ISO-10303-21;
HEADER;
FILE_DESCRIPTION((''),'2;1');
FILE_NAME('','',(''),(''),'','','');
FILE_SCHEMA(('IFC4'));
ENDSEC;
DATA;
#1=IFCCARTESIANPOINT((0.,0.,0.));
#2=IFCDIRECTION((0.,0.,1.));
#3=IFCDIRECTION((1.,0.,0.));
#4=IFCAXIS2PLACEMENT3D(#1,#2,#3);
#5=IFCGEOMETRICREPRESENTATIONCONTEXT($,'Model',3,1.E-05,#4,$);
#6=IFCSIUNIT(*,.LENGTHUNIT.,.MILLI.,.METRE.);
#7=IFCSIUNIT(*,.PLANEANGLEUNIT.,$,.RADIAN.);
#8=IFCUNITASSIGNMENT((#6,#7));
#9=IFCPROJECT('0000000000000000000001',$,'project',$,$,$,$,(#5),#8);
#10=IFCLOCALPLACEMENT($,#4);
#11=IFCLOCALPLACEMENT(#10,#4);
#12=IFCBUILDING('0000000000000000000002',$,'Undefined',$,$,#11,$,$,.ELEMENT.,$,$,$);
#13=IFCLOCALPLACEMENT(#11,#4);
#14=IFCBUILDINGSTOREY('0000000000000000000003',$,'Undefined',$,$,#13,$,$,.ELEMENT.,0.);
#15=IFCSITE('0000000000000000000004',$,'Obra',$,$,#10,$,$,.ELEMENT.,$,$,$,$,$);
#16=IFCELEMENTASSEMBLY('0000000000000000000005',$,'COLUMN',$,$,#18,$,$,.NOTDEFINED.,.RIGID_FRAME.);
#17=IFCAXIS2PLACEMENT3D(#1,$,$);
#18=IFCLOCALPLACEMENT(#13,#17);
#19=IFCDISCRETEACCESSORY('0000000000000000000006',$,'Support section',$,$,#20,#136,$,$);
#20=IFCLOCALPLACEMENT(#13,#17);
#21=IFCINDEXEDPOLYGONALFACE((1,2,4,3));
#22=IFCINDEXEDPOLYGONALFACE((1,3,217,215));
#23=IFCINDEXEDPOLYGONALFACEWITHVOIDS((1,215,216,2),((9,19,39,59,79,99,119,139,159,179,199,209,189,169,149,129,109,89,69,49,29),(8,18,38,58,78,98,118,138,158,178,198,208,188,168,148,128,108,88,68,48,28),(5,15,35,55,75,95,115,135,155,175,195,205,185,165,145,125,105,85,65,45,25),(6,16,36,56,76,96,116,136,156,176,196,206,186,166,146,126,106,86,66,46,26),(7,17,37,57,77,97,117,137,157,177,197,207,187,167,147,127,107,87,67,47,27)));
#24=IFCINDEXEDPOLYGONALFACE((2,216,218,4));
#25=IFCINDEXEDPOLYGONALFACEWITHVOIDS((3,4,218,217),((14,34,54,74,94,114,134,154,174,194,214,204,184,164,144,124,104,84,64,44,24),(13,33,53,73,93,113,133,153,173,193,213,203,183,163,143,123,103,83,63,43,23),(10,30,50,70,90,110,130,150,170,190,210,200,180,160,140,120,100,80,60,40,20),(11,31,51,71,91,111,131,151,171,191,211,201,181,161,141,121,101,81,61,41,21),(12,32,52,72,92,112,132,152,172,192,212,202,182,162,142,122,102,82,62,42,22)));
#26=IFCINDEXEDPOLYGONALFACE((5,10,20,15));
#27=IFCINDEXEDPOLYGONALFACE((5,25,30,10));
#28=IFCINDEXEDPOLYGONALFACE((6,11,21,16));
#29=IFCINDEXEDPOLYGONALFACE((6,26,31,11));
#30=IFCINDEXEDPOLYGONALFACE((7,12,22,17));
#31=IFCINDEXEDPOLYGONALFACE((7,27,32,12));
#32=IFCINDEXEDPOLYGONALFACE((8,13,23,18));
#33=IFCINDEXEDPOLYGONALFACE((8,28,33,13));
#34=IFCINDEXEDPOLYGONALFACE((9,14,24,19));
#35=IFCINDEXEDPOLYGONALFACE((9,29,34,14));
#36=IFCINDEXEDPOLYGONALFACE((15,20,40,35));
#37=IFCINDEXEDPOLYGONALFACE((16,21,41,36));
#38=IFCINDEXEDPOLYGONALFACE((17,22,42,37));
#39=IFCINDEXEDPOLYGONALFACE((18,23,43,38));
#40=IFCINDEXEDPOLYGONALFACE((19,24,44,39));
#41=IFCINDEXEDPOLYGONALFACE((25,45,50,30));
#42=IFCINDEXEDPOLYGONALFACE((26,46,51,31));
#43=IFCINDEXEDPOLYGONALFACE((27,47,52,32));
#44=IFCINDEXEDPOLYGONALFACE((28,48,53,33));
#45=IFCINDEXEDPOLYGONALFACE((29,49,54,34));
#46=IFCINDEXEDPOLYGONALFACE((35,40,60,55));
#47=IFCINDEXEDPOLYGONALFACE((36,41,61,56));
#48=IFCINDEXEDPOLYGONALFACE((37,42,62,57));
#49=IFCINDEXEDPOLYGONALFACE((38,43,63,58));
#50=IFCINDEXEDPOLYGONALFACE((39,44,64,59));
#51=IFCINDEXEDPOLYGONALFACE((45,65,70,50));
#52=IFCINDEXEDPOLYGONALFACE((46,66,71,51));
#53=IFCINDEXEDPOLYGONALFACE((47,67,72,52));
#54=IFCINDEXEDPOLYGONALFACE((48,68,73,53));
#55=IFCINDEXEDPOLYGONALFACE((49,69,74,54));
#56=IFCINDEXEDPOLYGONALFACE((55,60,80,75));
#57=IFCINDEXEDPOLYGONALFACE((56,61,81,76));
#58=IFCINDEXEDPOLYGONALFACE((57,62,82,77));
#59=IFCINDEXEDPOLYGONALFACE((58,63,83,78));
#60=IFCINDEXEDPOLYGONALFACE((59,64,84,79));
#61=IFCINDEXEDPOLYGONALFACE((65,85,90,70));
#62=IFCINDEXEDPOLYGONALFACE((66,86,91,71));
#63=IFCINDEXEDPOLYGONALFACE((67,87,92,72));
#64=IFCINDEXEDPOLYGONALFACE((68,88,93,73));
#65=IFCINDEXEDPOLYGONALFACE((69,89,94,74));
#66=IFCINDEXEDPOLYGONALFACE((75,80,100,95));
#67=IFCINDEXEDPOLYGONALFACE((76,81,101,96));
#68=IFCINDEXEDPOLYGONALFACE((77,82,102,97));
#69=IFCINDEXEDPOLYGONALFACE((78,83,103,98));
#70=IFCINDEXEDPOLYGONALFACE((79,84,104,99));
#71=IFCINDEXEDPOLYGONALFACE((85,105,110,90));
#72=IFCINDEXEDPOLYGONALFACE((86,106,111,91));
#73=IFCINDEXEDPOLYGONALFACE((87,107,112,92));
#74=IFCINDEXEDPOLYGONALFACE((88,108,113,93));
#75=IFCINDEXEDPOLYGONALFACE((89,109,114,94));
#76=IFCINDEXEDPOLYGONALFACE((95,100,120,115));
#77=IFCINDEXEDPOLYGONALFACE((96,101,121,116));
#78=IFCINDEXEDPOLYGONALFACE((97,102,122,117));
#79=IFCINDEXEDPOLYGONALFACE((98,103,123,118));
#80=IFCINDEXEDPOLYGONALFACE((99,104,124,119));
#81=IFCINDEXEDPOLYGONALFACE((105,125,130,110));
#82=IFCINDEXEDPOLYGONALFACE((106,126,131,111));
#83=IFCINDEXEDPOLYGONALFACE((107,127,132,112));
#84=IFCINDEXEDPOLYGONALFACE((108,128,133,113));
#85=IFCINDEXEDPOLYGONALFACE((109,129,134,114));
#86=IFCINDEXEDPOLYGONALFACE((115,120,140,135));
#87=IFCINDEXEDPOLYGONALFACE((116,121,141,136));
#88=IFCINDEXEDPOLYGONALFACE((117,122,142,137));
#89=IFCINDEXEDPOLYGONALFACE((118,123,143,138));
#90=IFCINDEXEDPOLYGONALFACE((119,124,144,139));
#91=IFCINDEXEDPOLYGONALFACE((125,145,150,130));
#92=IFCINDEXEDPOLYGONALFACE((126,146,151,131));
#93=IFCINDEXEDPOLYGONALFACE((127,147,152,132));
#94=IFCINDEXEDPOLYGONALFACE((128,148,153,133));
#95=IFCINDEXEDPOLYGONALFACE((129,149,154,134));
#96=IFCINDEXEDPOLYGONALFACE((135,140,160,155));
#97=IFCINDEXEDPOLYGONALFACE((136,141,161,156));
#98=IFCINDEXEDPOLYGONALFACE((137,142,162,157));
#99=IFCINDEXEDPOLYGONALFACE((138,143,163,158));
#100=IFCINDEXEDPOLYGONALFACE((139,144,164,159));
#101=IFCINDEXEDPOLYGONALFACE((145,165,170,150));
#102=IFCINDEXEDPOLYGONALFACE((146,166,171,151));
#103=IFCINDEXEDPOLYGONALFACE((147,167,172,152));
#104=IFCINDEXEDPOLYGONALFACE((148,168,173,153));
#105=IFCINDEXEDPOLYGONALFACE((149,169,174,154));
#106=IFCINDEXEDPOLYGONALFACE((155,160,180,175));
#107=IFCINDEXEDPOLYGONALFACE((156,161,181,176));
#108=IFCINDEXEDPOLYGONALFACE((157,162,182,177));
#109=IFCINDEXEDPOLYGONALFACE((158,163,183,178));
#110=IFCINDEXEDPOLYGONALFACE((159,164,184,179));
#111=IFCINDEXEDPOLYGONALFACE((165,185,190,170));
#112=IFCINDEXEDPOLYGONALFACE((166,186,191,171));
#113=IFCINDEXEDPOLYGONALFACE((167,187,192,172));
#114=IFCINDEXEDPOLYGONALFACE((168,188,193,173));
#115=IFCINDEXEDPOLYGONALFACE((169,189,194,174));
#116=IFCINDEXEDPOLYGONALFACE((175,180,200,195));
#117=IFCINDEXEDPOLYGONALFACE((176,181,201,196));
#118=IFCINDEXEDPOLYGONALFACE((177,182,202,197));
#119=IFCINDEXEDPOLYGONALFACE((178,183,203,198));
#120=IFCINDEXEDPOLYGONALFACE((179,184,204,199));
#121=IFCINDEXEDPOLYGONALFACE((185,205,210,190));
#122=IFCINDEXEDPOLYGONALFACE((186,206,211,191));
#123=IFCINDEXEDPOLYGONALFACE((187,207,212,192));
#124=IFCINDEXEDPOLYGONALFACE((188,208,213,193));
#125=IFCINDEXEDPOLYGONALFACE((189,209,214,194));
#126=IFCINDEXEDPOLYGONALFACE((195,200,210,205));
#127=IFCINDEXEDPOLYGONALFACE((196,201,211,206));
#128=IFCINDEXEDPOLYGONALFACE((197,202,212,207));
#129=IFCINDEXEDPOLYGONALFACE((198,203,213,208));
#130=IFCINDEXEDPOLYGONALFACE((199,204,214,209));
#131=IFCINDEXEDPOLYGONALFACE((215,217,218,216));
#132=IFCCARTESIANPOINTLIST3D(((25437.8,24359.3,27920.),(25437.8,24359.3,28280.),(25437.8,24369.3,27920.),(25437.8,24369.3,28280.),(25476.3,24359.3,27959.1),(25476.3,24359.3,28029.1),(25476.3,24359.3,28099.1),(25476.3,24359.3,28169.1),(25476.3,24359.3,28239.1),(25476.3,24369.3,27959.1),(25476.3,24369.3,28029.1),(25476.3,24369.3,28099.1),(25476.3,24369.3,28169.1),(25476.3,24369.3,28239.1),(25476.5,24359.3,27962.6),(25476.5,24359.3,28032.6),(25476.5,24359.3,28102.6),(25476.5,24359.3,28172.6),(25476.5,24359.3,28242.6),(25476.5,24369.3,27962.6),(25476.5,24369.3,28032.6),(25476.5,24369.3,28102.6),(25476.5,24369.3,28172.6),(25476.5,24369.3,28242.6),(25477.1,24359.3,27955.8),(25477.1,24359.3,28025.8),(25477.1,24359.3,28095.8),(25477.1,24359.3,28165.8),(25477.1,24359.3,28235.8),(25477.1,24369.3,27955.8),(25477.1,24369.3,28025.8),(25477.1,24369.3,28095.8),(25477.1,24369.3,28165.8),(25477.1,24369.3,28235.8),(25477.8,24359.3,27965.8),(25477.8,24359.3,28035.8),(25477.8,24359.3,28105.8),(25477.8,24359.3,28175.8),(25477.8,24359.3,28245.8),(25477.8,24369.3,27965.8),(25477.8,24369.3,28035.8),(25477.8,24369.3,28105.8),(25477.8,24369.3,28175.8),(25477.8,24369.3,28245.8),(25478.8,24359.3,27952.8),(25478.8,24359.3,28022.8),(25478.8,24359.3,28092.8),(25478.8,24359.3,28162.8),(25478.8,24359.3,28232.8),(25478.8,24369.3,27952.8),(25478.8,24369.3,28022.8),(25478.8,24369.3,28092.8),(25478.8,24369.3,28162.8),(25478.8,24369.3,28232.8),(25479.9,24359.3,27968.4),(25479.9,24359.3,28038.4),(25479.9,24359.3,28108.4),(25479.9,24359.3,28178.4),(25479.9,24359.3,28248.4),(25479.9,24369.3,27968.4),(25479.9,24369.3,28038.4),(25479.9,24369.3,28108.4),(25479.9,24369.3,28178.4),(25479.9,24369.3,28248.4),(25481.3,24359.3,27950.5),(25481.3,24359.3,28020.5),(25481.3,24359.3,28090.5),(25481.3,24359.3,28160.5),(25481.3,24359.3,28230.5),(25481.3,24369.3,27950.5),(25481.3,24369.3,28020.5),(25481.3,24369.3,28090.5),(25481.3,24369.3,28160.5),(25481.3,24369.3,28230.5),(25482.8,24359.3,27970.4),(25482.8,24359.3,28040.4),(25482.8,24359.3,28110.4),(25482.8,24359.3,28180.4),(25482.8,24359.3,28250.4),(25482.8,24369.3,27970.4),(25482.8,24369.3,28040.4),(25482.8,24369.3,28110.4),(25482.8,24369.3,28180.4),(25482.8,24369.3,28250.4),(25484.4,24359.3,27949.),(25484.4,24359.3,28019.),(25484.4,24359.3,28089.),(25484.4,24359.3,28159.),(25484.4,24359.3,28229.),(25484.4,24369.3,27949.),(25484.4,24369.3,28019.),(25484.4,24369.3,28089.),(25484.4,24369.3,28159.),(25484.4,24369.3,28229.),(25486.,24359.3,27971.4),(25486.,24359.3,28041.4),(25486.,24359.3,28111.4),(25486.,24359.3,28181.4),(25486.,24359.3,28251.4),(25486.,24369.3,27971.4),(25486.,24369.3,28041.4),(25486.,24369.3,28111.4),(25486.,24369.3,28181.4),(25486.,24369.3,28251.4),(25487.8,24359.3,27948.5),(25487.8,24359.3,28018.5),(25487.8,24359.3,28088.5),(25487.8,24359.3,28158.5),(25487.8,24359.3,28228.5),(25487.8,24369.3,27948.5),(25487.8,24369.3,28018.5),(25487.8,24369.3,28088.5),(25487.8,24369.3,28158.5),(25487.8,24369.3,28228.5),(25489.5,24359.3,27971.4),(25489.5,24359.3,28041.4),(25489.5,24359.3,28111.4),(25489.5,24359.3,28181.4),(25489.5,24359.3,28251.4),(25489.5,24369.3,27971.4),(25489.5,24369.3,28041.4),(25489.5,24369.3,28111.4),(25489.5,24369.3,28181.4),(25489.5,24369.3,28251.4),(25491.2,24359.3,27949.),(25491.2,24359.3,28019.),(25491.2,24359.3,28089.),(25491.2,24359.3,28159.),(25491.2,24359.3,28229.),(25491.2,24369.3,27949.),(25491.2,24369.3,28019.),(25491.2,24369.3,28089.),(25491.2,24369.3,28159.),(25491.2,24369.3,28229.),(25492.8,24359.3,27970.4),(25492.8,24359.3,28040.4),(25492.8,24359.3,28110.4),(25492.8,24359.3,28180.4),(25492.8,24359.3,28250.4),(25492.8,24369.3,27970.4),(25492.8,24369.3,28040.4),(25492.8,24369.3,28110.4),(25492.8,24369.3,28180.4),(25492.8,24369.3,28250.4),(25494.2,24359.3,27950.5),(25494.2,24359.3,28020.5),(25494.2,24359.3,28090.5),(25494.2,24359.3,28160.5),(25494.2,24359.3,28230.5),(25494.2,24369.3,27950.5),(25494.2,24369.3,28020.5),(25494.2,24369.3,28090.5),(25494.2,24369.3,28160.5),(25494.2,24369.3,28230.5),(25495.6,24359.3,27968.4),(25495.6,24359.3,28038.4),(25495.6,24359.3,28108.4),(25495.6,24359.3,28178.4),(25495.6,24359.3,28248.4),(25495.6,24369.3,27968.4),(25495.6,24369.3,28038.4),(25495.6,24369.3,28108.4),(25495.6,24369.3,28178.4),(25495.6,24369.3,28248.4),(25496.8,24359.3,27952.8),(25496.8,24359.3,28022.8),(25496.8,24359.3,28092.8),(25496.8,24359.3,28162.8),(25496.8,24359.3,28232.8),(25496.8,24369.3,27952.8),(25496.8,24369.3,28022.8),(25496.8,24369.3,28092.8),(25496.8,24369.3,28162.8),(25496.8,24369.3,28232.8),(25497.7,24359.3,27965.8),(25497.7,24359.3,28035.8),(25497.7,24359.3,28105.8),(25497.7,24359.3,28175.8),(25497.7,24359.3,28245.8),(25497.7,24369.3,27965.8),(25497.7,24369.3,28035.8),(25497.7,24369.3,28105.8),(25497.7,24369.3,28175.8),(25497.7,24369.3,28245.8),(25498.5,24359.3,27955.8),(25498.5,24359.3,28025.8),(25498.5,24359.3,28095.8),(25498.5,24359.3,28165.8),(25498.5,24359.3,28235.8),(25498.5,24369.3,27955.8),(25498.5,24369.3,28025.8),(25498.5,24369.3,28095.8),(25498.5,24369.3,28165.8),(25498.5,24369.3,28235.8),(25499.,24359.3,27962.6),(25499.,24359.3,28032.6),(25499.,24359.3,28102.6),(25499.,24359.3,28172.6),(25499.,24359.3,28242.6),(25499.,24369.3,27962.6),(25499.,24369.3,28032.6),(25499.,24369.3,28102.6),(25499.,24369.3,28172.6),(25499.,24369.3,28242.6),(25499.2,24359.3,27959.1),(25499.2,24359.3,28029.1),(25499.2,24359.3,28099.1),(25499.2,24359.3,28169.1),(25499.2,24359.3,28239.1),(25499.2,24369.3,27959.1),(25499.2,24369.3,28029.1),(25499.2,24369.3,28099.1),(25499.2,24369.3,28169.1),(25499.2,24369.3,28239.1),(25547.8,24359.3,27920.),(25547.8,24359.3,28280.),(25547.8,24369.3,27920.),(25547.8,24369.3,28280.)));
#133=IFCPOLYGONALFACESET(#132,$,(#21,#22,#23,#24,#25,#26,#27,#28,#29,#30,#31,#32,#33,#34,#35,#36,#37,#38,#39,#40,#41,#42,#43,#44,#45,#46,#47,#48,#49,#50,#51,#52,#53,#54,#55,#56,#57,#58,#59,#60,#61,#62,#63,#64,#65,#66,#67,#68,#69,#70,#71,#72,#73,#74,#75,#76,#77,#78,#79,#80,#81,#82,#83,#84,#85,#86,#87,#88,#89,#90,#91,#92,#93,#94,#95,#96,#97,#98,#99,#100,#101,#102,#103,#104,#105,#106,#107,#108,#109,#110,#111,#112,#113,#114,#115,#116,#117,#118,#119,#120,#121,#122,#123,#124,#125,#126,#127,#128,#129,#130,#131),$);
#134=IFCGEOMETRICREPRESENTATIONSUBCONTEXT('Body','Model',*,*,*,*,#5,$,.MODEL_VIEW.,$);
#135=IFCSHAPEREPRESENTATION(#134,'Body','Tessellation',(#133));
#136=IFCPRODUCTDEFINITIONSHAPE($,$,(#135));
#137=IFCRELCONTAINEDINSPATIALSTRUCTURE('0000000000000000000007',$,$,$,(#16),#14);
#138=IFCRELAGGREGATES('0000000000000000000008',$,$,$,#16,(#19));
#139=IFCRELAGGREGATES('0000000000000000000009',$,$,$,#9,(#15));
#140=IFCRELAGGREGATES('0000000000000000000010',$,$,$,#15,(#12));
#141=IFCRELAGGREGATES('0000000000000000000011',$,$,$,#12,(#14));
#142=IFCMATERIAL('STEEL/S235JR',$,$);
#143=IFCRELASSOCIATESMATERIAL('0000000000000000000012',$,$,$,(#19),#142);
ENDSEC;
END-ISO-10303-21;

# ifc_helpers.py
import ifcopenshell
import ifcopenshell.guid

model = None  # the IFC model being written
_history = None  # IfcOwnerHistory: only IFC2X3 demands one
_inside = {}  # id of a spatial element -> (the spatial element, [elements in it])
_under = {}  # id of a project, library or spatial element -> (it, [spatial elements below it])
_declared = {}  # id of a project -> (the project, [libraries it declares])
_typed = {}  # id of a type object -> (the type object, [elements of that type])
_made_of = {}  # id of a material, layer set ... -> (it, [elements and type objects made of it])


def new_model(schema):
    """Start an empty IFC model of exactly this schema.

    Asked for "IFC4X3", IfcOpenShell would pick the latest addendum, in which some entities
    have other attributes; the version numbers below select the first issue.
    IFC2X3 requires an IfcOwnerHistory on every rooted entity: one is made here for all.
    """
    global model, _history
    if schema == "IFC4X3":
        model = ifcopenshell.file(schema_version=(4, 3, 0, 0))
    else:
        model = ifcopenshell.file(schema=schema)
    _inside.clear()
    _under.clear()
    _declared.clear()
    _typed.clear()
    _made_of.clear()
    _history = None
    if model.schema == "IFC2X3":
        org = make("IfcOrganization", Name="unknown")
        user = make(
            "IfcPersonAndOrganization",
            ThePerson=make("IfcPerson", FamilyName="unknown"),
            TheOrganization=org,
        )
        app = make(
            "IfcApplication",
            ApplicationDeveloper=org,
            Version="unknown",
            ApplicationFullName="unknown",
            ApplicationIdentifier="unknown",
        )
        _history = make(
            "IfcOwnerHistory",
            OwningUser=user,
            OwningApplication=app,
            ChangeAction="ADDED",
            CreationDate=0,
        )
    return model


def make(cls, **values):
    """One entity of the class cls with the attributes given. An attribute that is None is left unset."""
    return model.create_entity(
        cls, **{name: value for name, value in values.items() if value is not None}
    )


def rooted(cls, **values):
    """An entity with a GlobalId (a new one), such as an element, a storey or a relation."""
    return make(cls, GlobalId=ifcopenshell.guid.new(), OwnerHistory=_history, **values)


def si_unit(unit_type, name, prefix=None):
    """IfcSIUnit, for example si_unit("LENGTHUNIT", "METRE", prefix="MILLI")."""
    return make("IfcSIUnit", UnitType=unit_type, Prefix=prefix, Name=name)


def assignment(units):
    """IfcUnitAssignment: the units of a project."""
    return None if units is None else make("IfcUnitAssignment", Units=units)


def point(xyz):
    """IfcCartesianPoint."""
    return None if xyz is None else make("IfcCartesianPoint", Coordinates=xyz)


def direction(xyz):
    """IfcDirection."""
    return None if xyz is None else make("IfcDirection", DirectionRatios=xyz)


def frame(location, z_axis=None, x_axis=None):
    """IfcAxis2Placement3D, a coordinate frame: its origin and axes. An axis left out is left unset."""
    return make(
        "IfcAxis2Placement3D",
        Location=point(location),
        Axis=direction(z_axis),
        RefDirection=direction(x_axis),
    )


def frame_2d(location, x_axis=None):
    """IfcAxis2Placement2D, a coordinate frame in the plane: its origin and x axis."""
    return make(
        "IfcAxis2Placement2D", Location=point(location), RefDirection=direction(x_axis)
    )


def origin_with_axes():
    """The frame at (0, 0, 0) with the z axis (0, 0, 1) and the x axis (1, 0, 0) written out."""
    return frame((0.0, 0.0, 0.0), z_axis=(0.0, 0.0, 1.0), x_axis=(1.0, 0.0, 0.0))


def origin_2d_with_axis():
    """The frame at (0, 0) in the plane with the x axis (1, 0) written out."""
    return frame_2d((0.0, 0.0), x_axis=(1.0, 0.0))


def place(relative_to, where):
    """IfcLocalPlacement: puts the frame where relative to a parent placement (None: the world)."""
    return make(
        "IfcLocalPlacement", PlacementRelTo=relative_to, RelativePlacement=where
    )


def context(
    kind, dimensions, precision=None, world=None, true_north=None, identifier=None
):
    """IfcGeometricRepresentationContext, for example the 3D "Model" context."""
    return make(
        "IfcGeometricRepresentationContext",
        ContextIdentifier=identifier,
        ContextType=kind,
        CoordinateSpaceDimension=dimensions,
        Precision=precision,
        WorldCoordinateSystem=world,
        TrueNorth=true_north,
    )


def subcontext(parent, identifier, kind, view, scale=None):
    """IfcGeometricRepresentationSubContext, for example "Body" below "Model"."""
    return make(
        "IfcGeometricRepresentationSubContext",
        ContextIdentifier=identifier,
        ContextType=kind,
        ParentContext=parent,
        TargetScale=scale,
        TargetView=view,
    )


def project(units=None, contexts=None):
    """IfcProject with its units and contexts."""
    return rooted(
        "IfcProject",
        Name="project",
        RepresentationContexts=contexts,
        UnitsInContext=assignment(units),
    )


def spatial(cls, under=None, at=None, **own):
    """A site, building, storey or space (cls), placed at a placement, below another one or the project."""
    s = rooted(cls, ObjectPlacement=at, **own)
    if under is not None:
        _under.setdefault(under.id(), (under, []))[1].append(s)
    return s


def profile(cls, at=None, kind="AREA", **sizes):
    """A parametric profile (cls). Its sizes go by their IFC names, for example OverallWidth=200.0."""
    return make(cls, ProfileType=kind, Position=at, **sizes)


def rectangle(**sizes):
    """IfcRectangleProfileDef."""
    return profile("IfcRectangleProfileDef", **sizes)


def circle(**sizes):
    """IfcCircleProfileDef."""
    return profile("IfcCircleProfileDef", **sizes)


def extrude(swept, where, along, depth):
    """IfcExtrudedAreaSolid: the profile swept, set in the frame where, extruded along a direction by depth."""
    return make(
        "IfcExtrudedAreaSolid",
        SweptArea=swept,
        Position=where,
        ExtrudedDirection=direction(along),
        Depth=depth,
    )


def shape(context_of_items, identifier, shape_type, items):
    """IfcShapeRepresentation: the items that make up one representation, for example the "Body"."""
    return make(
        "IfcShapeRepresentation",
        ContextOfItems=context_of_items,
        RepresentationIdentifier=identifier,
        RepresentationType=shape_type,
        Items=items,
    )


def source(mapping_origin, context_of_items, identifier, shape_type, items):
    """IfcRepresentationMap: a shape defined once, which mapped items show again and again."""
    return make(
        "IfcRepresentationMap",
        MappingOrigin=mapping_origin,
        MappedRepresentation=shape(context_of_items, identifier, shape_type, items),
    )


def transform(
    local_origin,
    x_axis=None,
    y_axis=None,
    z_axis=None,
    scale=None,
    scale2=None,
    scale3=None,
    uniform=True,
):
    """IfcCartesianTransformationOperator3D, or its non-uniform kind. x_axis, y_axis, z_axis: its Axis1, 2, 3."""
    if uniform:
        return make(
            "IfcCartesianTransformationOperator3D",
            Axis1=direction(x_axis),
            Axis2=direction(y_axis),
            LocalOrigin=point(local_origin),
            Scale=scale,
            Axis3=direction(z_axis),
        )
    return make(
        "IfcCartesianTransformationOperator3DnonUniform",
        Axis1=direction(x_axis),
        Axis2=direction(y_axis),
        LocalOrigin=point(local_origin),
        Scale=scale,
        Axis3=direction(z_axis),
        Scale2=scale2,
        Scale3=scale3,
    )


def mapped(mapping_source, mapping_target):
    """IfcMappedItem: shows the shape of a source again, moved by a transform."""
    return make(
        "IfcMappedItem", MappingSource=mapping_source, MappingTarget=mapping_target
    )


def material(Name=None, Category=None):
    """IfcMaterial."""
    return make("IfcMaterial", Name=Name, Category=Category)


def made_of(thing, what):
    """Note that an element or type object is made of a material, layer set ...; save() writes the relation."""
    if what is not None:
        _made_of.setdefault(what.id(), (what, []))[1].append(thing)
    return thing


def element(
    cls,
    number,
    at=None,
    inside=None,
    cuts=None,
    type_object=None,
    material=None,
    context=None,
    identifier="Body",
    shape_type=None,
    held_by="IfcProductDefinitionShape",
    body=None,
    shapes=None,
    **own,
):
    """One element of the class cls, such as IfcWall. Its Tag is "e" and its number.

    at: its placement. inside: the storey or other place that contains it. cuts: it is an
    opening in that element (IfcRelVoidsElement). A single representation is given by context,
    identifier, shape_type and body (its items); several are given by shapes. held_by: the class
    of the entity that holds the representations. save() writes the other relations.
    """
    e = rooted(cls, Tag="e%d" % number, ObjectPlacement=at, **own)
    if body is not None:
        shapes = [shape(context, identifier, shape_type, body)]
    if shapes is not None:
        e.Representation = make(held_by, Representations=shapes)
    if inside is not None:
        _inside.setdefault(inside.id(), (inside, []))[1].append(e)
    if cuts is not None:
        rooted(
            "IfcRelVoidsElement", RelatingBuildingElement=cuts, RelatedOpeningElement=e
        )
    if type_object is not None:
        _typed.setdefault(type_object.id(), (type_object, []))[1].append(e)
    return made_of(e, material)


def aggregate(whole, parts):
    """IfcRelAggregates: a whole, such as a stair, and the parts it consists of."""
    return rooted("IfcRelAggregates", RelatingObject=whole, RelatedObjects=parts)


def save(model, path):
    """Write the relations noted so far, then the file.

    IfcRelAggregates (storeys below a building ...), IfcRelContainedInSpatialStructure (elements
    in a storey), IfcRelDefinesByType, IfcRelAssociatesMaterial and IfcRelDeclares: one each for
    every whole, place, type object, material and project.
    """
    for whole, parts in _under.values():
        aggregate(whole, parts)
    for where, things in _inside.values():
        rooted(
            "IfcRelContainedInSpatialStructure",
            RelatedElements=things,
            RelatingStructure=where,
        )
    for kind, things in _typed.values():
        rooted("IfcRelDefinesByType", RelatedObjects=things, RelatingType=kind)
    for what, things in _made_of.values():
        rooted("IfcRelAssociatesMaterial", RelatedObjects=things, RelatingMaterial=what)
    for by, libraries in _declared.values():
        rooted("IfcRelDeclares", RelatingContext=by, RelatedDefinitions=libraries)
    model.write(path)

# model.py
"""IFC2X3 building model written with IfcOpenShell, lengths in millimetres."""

from ifc_helpers import new_model, si_unit, frame, origin_with_axes, origin_2d_with_axis, place, context, subcontext, project, spatial, rectangle, circle, extrude, source, transform, mapped, material, element, aggregate, save


model = new_model("IFC2X3")

# Units and contexts
model_context = context("Model", 3, precision=1e-05, world=origin_with_axes())
body_context = subcontext(model_context, "Body", "Model", "MODEL_VIEW")
ifc_project = project(units=[si_unit("LENGTHUNIT", "METRE", prefix="MILLI"), si_unit("PLANEANGLEUNIT", "RADIAN")], contexts=[model_context])

# Site, building, storey
site_placement = place(None, origin_with_axes())
site = spatial("IfcSite", under=ifc_project, at=site_placement, Name="Obra", CompositionType="ELEMENT")
building_placement = place(site_placement, origin_with_axes())
building = spatial("IfcBuilding", under=site, at=building_placement, Name="Undefined", CompositionType="ELEMENT")
storey_placement = place(building_placement, origin_with_axes())
storey = spatial("IfcBuildingStorey", under=building, at=storey_placement, Name="Undefined", CompositionType="ELEMENT", Elevation=0.0)

# Element assembly
ifc_material_1 = material(Name="STEEL/S235JR")
assembly_1_placement = place(storey_placement, origin_with_axes())
assembly_1 = element("IfcElementAssembly", 1, at=assembly_1_placement, inside=storey, Name="COLUMN", AssemblyPlace="NOTDEFINED", PredefinedType="RIGID_FRAME")

# Shared definitions
shared_shape_1 = source(origin_with_axes(), body_context, "Body", "SweptSolid", [
    extrude(circle(Radius=11.5, at=origin_2d_with_axis()), frame((0.0, -14.4, 0.0), z_axis=(0.0, 1.0, 0.0), x_axis=(1.0, 0.0, 0.0)), (0.0, 0.0, 1.0), 10.2),
])

# Discrete accessory, opening
discrete_accessory_1_placement = place(assembly_1_placement, frame((25492.8, 24364.3, 27920.0), z_axis=(0.0, 0.0, 1.0), x_axis=(1.0, 0.0, 0.0)))
discrete_accessory_1 = element("IfcDiscreteAccessory", 2, at=discrete_accessory_1_placement, material=ifc_material_1, Name="Support section", context=body_context, shape_type="SweptSolid", body=[
    extrude(rectangle(XDim=10.0, YDim=110.0, at=origin_2d_with_axis()), frame((0.0, 0.0, 360.0), z_axis=(0.0, 0.0, -1.0), x_axis=(0.0, 1.0, 0.0)), (0.0, 0.0, 1.0), 360.0),
])
opening_1_placement = place(assembly_1_placement, frame((25537.8, 24355.0, 28300.0), z_axis=(-1.0, 0.0, 0.0), x_axis=(0.0, 0.0, -1.0)))
element("IfcOpeningElement", 3, at=opening_1_placement, cuts=discrete_accessory_1, ObjectType="Opening", context=body_context, shape_type="MappedRepresentation", body=[
    mapped(shared_shape_1, transform((60.0, 0.0, 50.0))),
    mapped(shared_shape_1, transform((130.0, 0.0, 50.0))),
    mapped(shared_shape_1, transform((200.0, 0.0, 50.0))),
    mapped(shared_shape_1, transform((270.0, 0.0, 50.0))),
    mapped(shared_shape_1, transform((340.0, 0.0, 50.0))),
])
aggregate(assembly_1, [discrete_accessory_1])

save(model, "model.ifc")
